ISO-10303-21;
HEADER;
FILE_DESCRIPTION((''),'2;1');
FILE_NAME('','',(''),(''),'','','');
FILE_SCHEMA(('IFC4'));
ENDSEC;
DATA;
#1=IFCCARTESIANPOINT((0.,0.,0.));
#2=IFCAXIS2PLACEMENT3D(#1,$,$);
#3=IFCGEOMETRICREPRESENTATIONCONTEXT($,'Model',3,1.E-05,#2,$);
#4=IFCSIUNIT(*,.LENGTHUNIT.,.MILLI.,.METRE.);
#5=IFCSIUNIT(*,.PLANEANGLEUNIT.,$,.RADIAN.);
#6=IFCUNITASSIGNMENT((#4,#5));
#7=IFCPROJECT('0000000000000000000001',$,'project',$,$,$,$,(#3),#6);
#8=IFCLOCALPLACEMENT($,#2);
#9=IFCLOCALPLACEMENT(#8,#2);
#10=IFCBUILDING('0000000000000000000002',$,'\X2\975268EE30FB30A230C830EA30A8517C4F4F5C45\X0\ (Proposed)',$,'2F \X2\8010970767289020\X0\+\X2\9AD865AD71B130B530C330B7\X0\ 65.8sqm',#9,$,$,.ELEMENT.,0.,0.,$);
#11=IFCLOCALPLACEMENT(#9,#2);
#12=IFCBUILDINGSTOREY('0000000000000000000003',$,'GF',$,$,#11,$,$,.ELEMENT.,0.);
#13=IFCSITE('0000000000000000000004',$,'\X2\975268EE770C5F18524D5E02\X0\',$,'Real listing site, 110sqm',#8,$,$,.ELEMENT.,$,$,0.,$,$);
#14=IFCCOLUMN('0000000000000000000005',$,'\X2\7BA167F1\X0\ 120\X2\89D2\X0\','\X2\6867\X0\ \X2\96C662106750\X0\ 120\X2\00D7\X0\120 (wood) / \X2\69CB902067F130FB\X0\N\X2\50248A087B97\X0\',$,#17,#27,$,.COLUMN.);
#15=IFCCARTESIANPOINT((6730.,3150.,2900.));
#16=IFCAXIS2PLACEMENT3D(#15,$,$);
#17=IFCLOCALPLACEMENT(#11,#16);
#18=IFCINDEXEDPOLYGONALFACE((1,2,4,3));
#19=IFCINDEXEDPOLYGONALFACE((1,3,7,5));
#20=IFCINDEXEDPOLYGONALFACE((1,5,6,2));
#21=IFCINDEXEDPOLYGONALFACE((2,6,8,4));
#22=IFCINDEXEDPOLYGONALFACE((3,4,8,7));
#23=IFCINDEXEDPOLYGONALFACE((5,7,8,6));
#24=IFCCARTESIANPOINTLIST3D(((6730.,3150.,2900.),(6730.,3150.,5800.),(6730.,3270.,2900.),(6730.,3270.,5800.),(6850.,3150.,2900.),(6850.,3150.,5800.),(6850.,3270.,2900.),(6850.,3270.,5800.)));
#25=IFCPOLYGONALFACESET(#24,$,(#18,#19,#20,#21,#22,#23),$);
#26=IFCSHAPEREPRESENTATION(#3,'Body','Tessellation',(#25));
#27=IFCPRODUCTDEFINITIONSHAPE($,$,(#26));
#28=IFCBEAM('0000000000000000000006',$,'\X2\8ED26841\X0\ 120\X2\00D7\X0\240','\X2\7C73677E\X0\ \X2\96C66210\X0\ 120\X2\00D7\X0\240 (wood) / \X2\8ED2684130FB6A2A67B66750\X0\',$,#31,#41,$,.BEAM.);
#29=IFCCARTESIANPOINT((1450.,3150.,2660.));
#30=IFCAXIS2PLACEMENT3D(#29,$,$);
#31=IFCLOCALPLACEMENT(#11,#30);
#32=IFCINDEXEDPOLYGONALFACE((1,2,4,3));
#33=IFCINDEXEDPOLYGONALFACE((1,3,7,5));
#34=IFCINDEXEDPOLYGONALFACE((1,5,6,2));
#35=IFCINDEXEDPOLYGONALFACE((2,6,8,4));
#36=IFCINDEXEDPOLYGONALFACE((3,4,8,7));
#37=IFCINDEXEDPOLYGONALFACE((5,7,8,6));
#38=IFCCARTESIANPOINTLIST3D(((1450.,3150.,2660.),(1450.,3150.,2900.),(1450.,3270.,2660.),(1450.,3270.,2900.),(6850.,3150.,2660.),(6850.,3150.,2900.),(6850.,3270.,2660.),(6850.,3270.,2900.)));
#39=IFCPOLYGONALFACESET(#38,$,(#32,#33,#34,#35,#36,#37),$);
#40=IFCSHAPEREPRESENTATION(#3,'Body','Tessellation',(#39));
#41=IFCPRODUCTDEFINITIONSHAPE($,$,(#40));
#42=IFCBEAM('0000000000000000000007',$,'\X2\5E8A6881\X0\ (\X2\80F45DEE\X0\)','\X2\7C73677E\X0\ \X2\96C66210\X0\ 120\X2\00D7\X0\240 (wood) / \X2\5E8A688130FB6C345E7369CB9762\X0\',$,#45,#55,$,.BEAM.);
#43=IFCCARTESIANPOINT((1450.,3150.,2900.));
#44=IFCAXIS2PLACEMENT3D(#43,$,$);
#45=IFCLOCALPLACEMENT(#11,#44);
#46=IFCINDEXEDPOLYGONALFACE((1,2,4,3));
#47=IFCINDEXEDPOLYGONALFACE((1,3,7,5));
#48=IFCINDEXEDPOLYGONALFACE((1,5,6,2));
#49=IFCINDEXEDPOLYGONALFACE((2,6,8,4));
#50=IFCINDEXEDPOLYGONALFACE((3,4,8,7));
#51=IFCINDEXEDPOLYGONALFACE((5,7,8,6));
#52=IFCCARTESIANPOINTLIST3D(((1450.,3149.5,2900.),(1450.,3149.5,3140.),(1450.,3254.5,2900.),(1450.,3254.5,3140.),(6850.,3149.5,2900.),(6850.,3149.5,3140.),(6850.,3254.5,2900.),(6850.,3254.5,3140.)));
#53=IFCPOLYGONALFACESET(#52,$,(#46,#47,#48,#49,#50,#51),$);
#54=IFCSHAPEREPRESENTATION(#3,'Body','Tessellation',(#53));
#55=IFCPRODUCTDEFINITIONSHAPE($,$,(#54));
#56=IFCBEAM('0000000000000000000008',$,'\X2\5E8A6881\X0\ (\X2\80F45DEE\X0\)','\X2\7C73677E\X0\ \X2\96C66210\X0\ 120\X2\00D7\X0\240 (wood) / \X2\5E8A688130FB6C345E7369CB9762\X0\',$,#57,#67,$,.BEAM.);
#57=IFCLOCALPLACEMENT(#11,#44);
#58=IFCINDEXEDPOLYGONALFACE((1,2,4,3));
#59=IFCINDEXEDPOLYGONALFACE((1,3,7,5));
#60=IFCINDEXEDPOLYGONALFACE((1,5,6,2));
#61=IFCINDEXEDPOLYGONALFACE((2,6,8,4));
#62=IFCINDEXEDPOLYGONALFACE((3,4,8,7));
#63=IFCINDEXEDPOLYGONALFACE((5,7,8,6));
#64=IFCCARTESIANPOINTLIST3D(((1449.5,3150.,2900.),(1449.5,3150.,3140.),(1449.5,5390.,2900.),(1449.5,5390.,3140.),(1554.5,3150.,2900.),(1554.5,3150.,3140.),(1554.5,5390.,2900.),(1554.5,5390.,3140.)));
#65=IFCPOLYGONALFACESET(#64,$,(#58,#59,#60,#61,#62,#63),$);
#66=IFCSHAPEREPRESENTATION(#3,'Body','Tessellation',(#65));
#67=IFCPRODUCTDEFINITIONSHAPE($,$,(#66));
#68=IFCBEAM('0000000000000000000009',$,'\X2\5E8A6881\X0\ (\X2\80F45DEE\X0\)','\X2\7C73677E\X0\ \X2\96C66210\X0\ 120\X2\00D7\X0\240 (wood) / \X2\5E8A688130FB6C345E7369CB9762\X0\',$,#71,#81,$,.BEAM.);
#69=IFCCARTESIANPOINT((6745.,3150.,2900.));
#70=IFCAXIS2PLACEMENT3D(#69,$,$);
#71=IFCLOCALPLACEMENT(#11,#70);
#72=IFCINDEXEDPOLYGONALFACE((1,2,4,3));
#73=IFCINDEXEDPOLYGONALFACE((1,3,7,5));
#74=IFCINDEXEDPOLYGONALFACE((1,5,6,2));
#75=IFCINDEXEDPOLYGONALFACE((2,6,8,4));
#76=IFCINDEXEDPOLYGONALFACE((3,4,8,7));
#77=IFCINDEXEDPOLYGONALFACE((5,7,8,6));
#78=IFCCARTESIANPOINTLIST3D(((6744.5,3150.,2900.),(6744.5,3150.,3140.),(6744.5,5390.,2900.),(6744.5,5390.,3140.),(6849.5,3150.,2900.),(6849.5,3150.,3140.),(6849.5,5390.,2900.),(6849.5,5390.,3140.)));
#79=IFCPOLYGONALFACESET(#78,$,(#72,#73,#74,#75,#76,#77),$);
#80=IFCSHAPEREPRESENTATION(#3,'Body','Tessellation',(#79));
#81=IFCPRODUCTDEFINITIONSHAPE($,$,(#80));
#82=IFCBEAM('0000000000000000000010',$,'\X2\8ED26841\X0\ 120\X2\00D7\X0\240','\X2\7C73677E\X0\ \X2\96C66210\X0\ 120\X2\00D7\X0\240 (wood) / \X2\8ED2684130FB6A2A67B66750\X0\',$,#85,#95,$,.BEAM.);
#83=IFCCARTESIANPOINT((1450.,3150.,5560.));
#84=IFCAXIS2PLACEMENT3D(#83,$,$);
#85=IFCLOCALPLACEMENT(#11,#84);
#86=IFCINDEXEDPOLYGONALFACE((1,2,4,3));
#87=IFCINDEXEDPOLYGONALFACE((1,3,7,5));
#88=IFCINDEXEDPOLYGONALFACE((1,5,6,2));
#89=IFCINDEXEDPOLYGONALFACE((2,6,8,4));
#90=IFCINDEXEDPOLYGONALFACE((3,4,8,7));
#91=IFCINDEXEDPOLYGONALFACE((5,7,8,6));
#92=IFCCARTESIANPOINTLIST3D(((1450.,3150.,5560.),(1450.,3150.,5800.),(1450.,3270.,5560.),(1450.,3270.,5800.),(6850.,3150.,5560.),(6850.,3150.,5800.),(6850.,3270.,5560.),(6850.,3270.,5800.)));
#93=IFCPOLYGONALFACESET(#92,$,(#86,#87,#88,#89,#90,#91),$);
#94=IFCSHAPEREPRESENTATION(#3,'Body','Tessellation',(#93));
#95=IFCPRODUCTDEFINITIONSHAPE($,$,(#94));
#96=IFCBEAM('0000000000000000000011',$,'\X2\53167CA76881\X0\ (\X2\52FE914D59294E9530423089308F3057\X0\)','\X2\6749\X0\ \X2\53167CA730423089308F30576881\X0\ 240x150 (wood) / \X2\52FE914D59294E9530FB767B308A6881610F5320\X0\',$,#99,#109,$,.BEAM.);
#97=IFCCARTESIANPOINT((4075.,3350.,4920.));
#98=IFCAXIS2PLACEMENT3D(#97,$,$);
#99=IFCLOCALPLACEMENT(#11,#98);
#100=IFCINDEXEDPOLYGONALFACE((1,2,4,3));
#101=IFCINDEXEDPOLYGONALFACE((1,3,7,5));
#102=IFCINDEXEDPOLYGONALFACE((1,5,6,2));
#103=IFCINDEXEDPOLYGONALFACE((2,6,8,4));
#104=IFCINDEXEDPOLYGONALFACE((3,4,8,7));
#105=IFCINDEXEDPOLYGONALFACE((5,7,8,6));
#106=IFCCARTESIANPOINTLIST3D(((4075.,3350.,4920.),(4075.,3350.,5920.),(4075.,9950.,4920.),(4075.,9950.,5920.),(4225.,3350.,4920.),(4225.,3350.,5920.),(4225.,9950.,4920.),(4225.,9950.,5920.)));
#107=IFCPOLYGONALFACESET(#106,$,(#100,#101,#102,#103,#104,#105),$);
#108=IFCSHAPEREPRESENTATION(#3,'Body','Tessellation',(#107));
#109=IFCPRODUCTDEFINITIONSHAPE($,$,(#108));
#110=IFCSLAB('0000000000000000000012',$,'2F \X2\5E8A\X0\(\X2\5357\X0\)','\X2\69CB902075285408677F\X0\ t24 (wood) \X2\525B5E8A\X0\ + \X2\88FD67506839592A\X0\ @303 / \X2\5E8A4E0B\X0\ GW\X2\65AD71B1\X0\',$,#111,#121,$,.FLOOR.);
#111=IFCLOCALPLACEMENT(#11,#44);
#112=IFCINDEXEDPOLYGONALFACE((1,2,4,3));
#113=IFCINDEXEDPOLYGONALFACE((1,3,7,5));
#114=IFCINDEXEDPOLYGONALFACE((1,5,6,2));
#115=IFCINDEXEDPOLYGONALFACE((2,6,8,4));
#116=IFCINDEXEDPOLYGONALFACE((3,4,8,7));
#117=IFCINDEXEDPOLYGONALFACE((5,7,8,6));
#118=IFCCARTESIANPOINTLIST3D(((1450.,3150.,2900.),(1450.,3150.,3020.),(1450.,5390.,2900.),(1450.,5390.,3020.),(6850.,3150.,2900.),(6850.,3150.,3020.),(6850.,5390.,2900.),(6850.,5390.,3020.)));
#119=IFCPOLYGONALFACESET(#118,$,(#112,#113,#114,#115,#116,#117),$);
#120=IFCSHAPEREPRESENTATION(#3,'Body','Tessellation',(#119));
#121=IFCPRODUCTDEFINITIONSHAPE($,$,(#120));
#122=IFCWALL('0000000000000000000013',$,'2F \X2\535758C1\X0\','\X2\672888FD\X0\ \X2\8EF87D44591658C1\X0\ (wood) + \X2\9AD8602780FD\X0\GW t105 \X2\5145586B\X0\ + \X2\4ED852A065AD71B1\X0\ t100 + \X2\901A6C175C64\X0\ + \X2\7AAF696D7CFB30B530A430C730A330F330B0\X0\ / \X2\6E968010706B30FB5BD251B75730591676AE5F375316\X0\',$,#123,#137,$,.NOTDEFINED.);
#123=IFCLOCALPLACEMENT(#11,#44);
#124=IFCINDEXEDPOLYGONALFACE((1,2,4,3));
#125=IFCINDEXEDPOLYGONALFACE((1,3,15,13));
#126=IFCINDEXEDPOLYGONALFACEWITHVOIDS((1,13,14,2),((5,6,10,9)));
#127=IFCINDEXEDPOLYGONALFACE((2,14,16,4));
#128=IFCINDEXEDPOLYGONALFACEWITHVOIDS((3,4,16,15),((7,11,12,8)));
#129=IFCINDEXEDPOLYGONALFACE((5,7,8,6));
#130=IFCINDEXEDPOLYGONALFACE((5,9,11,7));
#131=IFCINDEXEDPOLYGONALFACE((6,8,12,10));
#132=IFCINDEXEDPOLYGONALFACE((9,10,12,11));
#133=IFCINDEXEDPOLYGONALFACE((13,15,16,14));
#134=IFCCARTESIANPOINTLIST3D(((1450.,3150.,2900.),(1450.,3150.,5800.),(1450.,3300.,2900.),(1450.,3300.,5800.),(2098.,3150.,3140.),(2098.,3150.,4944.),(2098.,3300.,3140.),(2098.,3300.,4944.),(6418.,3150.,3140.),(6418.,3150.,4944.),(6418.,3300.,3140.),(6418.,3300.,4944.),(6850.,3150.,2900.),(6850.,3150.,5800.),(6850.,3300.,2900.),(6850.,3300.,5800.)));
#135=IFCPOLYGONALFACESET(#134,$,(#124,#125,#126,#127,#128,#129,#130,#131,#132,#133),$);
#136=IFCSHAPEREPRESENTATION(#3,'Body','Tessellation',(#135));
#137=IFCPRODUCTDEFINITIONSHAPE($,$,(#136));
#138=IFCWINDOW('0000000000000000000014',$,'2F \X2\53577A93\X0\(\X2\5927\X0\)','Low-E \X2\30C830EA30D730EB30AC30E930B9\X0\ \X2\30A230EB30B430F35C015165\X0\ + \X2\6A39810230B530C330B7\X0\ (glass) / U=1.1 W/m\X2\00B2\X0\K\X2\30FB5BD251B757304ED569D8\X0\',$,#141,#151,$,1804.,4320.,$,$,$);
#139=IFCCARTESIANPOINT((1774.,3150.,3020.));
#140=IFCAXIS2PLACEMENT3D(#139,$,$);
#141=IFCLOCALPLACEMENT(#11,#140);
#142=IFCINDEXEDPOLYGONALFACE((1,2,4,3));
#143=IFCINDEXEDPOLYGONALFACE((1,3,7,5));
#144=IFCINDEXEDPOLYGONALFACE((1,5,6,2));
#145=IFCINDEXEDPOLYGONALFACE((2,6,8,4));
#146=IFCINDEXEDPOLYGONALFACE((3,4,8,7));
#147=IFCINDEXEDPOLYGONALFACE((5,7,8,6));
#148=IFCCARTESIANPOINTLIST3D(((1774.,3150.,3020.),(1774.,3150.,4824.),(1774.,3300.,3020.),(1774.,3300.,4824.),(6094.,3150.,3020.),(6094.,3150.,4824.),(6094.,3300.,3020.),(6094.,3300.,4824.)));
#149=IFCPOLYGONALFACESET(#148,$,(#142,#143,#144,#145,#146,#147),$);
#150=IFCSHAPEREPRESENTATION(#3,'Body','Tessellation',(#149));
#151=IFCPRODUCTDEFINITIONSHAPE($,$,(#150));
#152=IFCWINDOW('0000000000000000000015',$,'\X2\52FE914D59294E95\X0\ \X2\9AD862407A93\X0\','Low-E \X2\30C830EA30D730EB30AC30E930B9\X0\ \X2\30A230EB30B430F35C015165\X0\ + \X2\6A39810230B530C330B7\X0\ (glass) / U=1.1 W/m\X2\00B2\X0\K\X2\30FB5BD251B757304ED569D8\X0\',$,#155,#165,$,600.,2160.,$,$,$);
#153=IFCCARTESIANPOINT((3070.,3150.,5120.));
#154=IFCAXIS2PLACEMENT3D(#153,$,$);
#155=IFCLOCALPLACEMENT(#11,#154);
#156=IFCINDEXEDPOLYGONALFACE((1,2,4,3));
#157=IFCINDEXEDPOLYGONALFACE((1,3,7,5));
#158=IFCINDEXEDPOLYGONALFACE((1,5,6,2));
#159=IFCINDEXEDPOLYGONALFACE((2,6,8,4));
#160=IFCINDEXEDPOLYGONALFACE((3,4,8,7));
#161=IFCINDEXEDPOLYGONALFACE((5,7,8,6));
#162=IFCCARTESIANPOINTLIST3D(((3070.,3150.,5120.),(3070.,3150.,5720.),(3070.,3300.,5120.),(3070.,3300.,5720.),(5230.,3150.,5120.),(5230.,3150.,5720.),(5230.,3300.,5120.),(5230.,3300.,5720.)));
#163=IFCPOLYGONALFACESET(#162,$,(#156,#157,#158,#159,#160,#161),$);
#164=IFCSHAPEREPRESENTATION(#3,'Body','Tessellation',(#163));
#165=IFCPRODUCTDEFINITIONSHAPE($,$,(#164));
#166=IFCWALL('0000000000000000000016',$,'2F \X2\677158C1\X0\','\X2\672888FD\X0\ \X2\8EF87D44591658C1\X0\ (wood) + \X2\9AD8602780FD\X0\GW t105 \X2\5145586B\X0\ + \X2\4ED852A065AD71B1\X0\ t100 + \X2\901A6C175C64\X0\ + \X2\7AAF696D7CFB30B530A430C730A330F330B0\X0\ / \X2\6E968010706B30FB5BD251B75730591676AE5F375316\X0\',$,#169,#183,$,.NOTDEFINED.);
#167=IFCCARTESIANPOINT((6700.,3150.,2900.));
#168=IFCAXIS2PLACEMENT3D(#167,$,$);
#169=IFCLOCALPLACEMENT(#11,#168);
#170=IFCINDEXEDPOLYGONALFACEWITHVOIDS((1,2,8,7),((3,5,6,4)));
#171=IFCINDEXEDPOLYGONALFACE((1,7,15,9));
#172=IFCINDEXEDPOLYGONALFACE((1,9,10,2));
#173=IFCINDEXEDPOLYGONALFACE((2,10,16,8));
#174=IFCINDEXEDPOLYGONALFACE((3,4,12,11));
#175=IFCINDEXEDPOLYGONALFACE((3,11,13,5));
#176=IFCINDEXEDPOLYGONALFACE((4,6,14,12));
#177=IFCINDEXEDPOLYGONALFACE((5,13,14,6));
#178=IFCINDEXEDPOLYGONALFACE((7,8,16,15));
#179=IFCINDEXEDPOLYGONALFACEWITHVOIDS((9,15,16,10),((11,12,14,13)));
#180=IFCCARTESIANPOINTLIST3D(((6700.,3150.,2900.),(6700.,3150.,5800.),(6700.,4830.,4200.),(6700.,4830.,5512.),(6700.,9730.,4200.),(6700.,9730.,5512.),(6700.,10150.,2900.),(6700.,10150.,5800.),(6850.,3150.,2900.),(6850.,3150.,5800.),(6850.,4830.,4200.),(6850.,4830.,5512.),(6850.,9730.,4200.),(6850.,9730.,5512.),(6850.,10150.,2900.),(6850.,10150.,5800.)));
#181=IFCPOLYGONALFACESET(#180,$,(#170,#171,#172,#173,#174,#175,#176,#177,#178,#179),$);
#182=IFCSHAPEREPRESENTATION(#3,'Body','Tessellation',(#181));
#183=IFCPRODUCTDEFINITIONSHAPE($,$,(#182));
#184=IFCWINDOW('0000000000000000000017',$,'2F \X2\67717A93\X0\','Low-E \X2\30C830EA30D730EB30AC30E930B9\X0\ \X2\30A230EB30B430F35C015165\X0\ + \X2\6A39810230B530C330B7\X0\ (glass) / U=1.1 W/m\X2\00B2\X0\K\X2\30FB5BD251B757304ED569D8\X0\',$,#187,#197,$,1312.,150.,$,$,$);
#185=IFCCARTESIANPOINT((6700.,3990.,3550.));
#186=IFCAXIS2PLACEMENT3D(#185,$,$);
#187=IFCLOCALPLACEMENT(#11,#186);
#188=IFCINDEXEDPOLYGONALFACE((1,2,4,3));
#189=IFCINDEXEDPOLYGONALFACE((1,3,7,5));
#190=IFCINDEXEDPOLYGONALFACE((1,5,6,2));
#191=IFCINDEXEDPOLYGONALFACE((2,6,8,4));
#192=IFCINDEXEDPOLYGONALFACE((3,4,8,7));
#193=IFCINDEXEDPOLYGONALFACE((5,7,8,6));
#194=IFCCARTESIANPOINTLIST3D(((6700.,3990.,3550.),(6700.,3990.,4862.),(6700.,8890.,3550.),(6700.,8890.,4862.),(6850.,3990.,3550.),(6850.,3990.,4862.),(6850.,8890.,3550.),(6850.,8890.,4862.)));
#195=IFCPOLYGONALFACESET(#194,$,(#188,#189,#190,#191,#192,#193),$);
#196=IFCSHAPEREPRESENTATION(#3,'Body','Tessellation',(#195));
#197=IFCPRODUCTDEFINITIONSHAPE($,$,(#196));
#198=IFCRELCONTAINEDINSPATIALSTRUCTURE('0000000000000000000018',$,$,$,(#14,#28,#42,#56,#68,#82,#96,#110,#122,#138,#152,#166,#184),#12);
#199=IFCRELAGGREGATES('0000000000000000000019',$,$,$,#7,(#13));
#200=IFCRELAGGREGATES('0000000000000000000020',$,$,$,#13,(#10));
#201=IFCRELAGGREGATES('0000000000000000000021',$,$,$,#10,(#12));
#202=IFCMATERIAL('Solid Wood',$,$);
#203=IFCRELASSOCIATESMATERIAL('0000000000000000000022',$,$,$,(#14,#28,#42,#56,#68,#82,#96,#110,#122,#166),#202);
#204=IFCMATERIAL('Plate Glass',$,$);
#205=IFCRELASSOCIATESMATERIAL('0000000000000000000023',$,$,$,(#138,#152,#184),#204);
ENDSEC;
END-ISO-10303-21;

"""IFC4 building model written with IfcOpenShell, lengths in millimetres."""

from ifc_helpers import new_model, si_unit, frame, frame_2d, origin, place, context, project, spatial, rectangle, extrude, material, element, fill, save


model = new_model("IFC4")

# Units and contexts
model_context = context("Model", 3, precision=1e-05, world=origin())
ifc_project = project(units=[si_unit("LENGTHUNIT", "METRE", prefix="MILLI"), si_unit("PLANEANGLEUNIT", "RADIAN")], contexts=[model_context])

# Site, building, storey
site_placement = place(None, origin())
site = spatial("IfcSite", under=ifc_project, at=site_placement, Name="青森県弘前市", ObjectType="Real listing site, 110sqm", CompositionType="ELEMENT", RefElevation=0.0)
building_placement = place(site_placement, origin())
building = spatial("IfcBuilding", under=site, at=building_placement, Name="青森・アトリエ兼住居 (Proposed)", ObjectType="2F 耐震木造+高断熱サッシ 65.8sqm", CompositionType="ELEMENT", ElevationOfRefHeight=0.0, ElevationOfTerrain=0.0)
storey_placement = place(building_placement, origin())
storey = spatial("IfcBuildingStorey", under=building, at=storey_placement, Name="GF", CompositionType="ELEMENT", Elevation=0.0)

# Column
ifc_material_1 = material(Name="Solid Wood")
column_1_placement = place(storey_placement, frame((6730.0, 3150.0, 2900.0)))
element("IfcColumn", 1, at=column_1_placement, inside=storey, material=ifc_material_1, Name="管柱 120角", Description="桧 集成材 120×120 (wood) / 構造柱・N値計算", PredefinedType="COLUMN", context=model_context, shape_type="SweptSolid", body=[
    extrude(rectangle(XDim=120.0, YDim=120.0, at=frame_2d((60.0, 60.0))), frame((6730.0, 3150.0, 2900.0)), (0.0, 0.0, 1.0), 2900.0),
])

# Beams
beam_1_placement = place(storey_placement, frame((1450.0, 3150.0, 2660.0)))
element("IfcBeam", 2, at=beam_1_placement, inside=storey, material=ifc_material_1, Name="軒桁 120×240", Description="米松 集成 120×240 (wood) / 軒桁・横架材", PredefinedType="BEAM", context=model_context, shape_type="SweptSolid", body=[
    extrude(rectangle(XDim=5400.0, YDim=120.0, at=frame_2d((2700.0, 60.0))), frame((1450.0, 3150.0, 2660.0)), (0.0, 0.0, 1.0), 240.0),
])
beam_2_placement = place(storey_placement, frame((1450.0, 3150.0, 2900.0)))
element("IfcBeam", 3, at=beam_2_placement, inside=storey, material=ifc_material_1, Name="床梁 (胴差)", Description="米松 集成 120×240 (wood) / 床梁・水平構面", PredefinedType="BEAM", context=model_context, shape_type="SweptSolid", body=[
    extrude(rectangle(XDim=5400.0, YDim=105.0, at=frame_2d((2700.0, 52.0))), frame((1450.0, 3150.0, 2900.0)), (0.0, 0.0, 1.0), 240.0),
])
beam_3_placement = place(storey_placement, frame((1450.0, 3150.0, 2900.0)))
element("IfcBeam", 4, at=beam_3_placement, inside=storey, material=ifc_material_1, Name="床梁 (胴差)", Description="米松 集成 120×240 (wood) / 床梁・水平構面", PredefinedType="BEAM", context=model_context, shape_type="SweptSolid", body=[
    extrude(rectangle(XDim=105.0, YDim=2240.0, at=frame_2d((52.0, 1120.0))), frame((1450.0, 3150.0, 2900.0)), (0.0, 0.0, 1.0), 240.0),
])
beam_4_placement = place(storey_placement, frame((6745.0, 3150.0, 2900.0)))
element("IfcBeam", 5, at=beam_4_placement, inside=storey, material=ifc_material_1, Name="床梁 (胴差)", Description="米松 集成 120×240 (wood) / 床梁・水平構面", PredefinedType="BEAM", context=model_context, shape_type="SweptSolid", body=[
    extrude(rectangle(XDim=105.0, YDim=2240.0, at=frame_2d((52.0, 1120.0))), frame((6745.0, 3150.0, 2900.0)), (0.0, 0.0, 1.0), 240.0),
])
beam_5_placement = place(storey_placement, frame((1450.0, 3150.0, 5560.0)))
element("IfcBeam", 6, at=beam_5_placement, inside=storey, material=ifc_material_1, Name="軒桁 120×240", Description="米松 集成 120×240 (wood) / 軒桁・横架材", PredefinedType="BEAM", context=model_context, shape_type="SweptSolid", body=[
    extrude(rectangle(XDim=5400.0, YDim=120.0, at=frame_2d((2700.0, 60.0))), frame((1450.0, 3150.0, 5560.0)), (0.0, 0.0, 1.0), 240.0),
])
beam_6_placement = place(storey_placement, frame((4075.0, 3350.0, 4920.0)))
element("IfcBeam", 7, at=beam_6_placement, inside=storey, material=ifc_material_1, Name="化粧梁 (勾配天井あらわし)", Description="杉 化粧あらわし梁 240x150 (wood) / 勾配天井・登り梁意匠", PredefinedType="BEAM", context=model_context, shape_type="SweptSolid", body=[
    extrude(rectangle(XDim=150.0, YDim=6600.0, at=frame_2d((75.0, 3300.0))), frame((4075.0, 3350.0, 4920.0)), (0.0, 0.0, 1.0), 1000.0),
])

# Slab
slab_placement = place(storey_placement, frame((1450.0, 3150.0, 2900.0)))
element("IfcSlab", 8, at=slab_placement, inside=storey, material=ifc_material_1, Name="2F 床(南)", Description="構造用合板 t24 (wood) 剛床 + 製材根太 @303 / 床下 GW断熱", PredefinedType="FLOOR", context=model_context, shape_type="SweptSolid", body=[
    extrude(rectangle(XDim=5400.0, YDim=2240.0, at=frame_2d((2700.0, 1120.0))), frame((1450.0, 3150.0, 2900.0)), (0.0, 0.0, 1.0), 120.0),
])

# Wall, openings, windows
wall_1_placement = place(storey_placement, frame((1450.0, 3150.0, 2900.0)))
wall_1 = element("IfcWall", 9, at=wall_1_placement, inside=storey, material=ifc_material_1, Name="2F 南壁", Description="木製 軸組外壁 (wood) + 高性能GW t105 充填 + 付加断熱 t100 + 通気層 + 窯業系サイディング / 準耐火・寒冷地外皮強化", PredefinedType="NOTDEFINED", context=model_context, shape_type="SweptSolid", body=[
    extrude(rectangle(XDim=5400.0, YDim=150.0, at=frame_2d((2700.0, 75.0))), frame((1450.0, 3150.0, 2900.0)), (0.0, 0.0, 1.0), 2900.0),
])
opening_1_placement = place(storey_placement, frame((1774.0, 3150.0, 3020.0)))
opening_1 = element("IfcOpeningElement", 10, at=opening_1_placement, cuts=wall_1, PredefinedType="NOTDEFINED", context=model_context, shape_type="SweptSolid", body=[
    extrude(rectangle(XDim=4320.0, YDim=150.0, at=frame_2d((2160.0, 75.0))), frame((1774.0, 3150.0, 3020.0)), (0.0, 0.0, 1.0), 1804.0),
])
opening_2_placement = place(storey_placement, frame((3070.0, 3150.0, 5120.0)))
opening_2 = element("IfcOpeningElement", 11, at=opening_2_placement, cuts=wall_1, PredefinedType="NOTDEFINED", context=model_context, shape_type="SweptSolid", body=[
    extrude(rectangle(XDim=2160.0, YDim=150.0, at=frame_2d((1080.0, 75.0))), frame((3070.0, 3150.0, 5120.0)), (0.0, 0.0, 1.0), 600.0),
])
ifc_material_2 = material(Name="Plate Glass")
window_1_placement = place(storey_placement, frame((1774.0, 3150.0, 3020.0)))
window_1 = element("IfcWindow", 12, at=window_1_placement, inside=storey, material=ifc_material_2, Name="2F 南窓(大)", Description="Low-E トリプルガラス アルゴン封入 + 樹脂サッシ (glass) / U=1.1 W/m²K・寒冷地仕様", OverallHeight=1804.0, OverallWidth=4320.0, context=model_context, shape_type="SweptSolid", body=[
    extrude(rectangle(XDim=4320.0, YDim=150.0, at=frame_2d((2160.0, 75.0))), frame((1774.0, 3150.0, 3020.0)), (0.0, 0.0, 1.0), 1804.0),
])
fill(opening_1, window_1)
window_2_placement = place(storey_placement, frame((3070.0, 3150.0, 5120.0)))
window_2 = element("IfcWindow", 13, at=window_2_placement, inside=storey, material=ifc_material_2, Name="勾配天井 高所窓", Description="Low-E トリプルガラス アルゴン封入 + 樹脂サッシ (glass) / U=1.1 W/m²K・寒冷地仕様", OverallHeight=600.0, OverallWidth=2160.0, context=model_context, shape_type="SweptSolid", body=[
    extrude(rectangle(XDim=2160.0, YDim=150.0, at=frame_2d((1080.0, 75.0))), frame((3070.0, 3150.0, 5120.0)), (0.0, 0.0, 1.0), 600.0),
])
fill(opening_2, window_2)

# Wall, opening, window
wall_2_placement = place(storey_placement, frame((6700.0, 3150.0, 2900.0)))
wall_2 = element("IfcWall", 14, at=wall_2_placement, inside=storey, material=ifc_material_1, Name="2F 東壁", Description="木製 軸組外壁 (wood) + 高性能GW t105 充填 + 付加断熱 t100 + 通気層 + 窯業系サイディング / 準耐火・寒冷地外皮強化", PredefinedType="NOTDEFINED", context=model_context, shape_type="SweptSolid", body=[
    extrude(rectangle(XDim=150.0, YDim=7000.0, at=frame_2d((75.0, 3500.0))), frame((6700.0, 3150.0, 2900.0)), (0.0, 0.0, 1.0), 2900.0),
])
opening_3_placement = place(storey_placement, frame((6700.0, 3990.0, 3550.0)))
opening_3 = element("IfcOpeningElement", 15, at=opening_3_placement, cuts=wall_2, PredefinedType="NOTDEFINED", context=model_context, shape_type="SweptSolid", body=[
    extrude(rectangle(XDim=150.0, YDim=4900.0, at=frame_2d((75.0, 2450.0))), frame((6700.0, 3990.0, 3550.0)), (0.0, 0.0, 1.0), 1312.0),
])
window_3_placement = place(storey_placement, frame((6700.0, 3990.0, 3550.0)))
window_3 = element("IfcWindow", 16, at=window_3_placement, inside=storey, material=ifc_material_2, Name="2F 東窓", Description="Low-E トリプルガラス アルゴン封入 + 樹脂サッシ (glass) / U=1.1 W/m²K・寒冷地仕様", OverallHeight=1312.0, OverallWidth=150.0, context=model_context, shape_type="SweptSolid", body=[
    extrude(rectangle(XDim=150.0, YDim=4900.0, at=frame_2d((75.0, 2450.0))), frame((6700.0, 3990.0, 3550.0)), (0.0, 0.0, 1.0), 1312.0),
])
fill(opening_3, window_3)

save(model, "model.ifc")
